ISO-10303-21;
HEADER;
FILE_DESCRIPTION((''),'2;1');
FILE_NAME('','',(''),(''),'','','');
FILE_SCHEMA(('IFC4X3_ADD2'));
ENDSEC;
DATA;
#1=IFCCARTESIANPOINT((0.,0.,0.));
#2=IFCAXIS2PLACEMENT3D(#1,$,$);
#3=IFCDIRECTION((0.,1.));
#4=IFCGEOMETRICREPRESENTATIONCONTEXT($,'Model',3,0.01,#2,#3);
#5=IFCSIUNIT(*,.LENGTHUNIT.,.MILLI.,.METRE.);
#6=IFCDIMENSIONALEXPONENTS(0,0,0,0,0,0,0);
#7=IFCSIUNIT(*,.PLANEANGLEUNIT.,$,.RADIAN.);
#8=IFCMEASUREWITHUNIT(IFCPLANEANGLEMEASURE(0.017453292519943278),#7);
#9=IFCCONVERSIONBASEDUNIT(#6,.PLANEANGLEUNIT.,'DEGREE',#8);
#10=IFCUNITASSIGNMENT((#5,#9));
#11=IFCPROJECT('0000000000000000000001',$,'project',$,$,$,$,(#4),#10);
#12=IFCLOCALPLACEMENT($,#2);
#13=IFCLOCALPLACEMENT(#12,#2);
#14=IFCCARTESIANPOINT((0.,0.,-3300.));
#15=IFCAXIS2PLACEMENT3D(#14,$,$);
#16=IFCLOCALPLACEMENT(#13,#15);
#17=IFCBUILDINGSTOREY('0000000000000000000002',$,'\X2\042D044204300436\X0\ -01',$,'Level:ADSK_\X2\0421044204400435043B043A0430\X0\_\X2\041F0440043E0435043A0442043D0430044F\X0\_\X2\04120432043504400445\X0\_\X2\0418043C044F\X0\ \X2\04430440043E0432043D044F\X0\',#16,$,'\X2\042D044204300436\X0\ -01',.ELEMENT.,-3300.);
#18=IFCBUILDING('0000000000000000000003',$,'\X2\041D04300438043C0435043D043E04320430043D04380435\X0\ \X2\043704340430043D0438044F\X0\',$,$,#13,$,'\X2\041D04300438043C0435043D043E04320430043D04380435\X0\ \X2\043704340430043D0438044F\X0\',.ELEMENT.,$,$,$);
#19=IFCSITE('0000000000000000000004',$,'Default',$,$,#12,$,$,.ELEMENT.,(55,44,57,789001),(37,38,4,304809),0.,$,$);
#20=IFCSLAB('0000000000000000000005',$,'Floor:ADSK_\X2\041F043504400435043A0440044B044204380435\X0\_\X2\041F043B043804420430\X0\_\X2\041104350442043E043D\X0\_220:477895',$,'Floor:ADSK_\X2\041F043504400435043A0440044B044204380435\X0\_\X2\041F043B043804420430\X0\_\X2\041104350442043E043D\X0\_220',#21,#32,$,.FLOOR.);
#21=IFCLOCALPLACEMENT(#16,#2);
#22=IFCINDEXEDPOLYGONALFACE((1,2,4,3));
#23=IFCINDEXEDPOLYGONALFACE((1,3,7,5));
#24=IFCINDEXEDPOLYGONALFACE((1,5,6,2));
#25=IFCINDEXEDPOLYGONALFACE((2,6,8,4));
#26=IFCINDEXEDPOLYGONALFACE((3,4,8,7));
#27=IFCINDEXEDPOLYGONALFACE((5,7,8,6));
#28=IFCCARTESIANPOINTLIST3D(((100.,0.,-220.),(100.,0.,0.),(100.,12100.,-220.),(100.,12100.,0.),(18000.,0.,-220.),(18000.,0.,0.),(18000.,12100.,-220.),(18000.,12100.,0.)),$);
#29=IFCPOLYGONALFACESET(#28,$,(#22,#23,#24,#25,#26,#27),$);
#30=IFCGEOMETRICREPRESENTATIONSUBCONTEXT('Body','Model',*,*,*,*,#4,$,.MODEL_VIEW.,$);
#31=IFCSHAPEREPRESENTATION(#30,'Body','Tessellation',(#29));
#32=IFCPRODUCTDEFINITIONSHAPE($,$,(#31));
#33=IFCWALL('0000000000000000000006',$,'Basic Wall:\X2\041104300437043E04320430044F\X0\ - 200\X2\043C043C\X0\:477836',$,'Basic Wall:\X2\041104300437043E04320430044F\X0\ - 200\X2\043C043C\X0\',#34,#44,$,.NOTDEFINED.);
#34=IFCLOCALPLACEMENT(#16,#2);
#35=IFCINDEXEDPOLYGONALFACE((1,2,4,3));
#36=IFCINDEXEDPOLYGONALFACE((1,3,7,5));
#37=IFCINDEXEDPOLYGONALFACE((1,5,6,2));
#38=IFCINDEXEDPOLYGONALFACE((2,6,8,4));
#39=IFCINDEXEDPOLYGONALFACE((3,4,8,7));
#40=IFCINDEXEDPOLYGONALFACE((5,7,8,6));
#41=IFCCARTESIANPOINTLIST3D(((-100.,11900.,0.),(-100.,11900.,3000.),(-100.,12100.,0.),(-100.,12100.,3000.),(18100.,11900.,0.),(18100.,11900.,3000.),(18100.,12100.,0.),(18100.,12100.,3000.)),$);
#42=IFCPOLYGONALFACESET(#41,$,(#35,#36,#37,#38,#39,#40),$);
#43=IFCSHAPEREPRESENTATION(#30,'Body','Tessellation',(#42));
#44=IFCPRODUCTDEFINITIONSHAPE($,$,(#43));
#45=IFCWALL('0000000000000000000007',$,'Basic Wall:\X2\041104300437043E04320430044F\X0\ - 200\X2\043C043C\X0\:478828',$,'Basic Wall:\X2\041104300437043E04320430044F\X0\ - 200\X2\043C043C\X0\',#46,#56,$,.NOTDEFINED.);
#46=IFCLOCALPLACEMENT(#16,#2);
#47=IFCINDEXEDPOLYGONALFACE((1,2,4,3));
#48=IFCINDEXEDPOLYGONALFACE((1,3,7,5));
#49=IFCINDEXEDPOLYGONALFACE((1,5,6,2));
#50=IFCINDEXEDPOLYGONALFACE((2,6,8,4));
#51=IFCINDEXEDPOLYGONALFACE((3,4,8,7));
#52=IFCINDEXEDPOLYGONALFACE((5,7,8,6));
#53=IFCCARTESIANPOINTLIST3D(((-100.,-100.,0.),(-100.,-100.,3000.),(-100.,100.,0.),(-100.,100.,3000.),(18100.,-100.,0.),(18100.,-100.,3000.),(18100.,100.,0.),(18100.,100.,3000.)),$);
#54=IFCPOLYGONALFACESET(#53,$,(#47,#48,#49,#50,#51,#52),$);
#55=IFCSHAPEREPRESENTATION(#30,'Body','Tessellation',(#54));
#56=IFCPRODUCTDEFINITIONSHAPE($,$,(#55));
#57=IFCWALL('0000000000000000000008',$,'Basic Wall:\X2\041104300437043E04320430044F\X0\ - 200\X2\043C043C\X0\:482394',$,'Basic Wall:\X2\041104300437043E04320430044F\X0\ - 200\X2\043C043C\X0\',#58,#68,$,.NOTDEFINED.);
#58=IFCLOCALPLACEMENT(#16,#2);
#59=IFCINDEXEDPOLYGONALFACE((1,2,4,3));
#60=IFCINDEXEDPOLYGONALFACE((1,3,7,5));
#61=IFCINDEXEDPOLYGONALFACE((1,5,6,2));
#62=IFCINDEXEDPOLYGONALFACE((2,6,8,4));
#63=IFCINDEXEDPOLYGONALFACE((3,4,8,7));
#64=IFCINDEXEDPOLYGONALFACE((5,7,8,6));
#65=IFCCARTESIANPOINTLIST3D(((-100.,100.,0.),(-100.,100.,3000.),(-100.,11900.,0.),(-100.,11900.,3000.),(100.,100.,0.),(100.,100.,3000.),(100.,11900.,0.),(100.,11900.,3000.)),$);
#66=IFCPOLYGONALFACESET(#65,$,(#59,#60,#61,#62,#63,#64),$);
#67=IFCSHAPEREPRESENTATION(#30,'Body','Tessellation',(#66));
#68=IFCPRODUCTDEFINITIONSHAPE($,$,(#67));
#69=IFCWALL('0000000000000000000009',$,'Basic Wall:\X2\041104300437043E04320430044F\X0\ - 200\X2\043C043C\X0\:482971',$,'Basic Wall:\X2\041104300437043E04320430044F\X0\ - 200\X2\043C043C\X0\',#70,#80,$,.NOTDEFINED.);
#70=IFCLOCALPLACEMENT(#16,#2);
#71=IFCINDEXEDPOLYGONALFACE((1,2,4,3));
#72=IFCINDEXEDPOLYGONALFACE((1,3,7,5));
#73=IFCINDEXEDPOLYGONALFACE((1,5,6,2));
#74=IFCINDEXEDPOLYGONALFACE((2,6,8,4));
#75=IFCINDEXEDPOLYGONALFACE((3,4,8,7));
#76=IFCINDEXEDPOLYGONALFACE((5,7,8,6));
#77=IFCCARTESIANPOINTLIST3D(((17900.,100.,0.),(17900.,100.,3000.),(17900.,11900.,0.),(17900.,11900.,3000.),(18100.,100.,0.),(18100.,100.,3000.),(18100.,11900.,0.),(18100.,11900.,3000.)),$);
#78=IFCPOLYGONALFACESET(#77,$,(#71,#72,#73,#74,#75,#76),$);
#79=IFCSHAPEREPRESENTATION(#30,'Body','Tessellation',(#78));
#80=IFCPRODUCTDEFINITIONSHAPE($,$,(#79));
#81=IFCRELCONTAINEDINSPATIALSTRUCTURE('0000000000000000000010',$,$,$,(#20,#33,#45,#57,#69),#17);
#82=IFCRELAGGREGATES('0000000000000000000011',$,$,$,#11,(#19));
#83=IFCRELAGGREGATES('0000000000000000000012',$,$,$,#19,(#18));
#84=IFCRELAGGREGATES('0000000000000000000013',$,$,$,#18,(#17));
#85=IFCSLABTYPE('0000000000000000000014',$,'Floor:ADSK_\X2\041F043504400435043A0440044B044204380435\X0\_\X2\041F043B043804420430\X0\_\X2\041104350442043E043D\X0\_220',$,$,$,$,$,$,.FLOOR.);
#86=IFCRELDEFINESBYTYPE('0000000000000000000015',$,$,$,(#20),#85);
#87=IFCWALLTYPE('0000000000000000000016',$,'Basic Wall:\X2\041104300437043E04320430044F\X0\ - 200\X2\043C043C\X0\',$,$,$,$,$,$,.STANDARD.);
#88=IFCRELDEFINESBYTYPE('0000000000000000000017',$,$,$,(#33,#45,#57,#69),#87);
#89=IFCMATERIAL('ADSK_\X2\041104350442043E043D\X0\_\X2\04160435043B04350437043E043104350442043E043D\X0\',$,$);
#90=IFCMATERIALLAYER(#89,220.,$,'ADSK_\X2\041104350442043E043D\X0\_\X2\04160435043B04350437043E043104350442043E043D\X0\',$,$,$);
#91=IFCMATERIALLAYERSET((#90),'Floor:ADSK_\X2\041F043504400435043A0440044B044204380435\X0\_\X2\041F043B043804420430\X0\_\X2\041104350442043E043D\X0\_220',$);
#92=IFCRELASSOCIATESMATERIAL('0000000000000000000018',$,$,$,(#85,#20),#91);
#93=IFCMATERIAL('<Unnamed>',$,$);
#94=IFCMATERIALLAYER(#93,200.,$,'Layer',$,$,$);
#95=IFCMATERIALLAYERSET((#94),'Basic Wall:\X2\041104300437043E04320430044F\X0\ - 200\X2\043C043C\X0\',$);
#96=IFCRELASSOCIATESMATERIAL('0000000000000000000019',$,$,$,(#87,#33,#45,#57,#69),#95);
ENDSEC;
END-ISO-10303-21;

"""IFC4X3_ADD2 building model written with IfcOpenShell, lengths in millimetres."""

from ifc_helpers import new_model, entity, si_unit, converted_unit, direction, frame, frame_2d, origin, origin_2d_with_axis, place, context, subcontext, project, spatial, rectangle, extrude, material, layer, layer_set, layer_usage, type_object, element, save


model = new_model("IFC4X3_ADD2")

# Units and contexts
model_context = context("Model", 3, precision=0.01, world=origin(), true_north=direction((0.0, 1.0)))
body_context = subcontext(model_context, "Body", "Model", "MODEL_VIEW")
ifc_project = project(units=[si_unit("LENGTHUNIT", "METRE", prefix="MILLI"), converted_unit("PLANEANGLEUNIT", "DEGREE", entity("IfcPlaneAngleMeasure", 0.017453292519943278), si_unit("PLANEANGLEUNIT", "RADIAN"), dimensions=[0, 0, 0, 0, 0, 0, 0])], contexts=[model_context])

# Site, building, storey
site_placement = place(None, origin())
site = spatial("IfcSite", under=ifc_project, at=site_placement, Name="Default", CompositionType="ELEMENT", RefLatitude=(55, 44, 57, 789001), RefLongitude=(37, 38, 4, 304809), RefElevation=0.0)
building_placement = place(site_placement, origin())
building = spatial("IfcBuilding", under=site, at=building_placement, Name="Наименование здания", LongName="Наименование здания", CompositionType="ELEMENT")
storey_placement = place(building_placement, frame((0.0, 0.0, -3300.0)))
storey = spatial("IfcBuildingStorey", under=building, at=storey_placement, Name="Этаж -01", ObjectType="Level:ADSK_Стрелка_Проектная_Вверх_Имя уровня", LongName="Этаж -01", CompositionType="ELEMENT", Elevation=-3300.0)

# Slab
ifc_material_1 = material(Name="ADSK_Бетон_Железобетон")
ifc_layer_1 = layer(ifc_material_1, 220.0, Name="ADSK_Бетон_Железобетон")
ifc_layer_set_1 = layer_set([ifc_layer_1], Name="Floor:ADSK_Перекрытие_Плита_Бетон_220")
ifc_layer_usage = layer_usage(ifc_layer_set_1, "AXIS3", "POSITIVE", 0.0)
slab_type = type_object("IfcSlabType", Name="Floor:ADSK_Перекрытие_Плита_Бетон_220", PredefinedType="FLOOR", material=ifc_layer_set_1)
slab_placement = place(storey_placement, origin())
element("IfcSlab", 1, at=slab_placement, inside=storey, type_object=slab_type, material=ifc_layer_usage, Name="Floor:ADSK_Перекрытие_Плита_Бетон_220:477895", ObjectType="Floor:ADSK_Перекрытие_Плита_Бетон_220", PredefinedType="FLOOR", context=body_context, shape_type="SweptSolid", body=[
    extrude(rectangle(XDim=12100.0, YDim=17900.0, at=origin_2d_with_axis()), frame((9050.0, 6050.0, 0.0), z_axis=(0.0, 0.0, -1.0), x_axis=(0.0, 1.0, 0.0)), (0.0, 0.0, 1.0), 220.0),
])

# Walls
ifc_material_2 = material(Name="<Unnamed>")
ifc_layer_2 = layer(ifc_material_2, 200.0, Name="Layer")
ifc_layer_set_2 = layer_set([ifc_layer_2], Name="Basic Wall:Базовая - 200мм")
wall_type = type_object("IfcWallType", Name="Basic Wall:Базовая - 200мм", PredefinedType="STANDARD", material=ifc_layer_set_2)
wall_1_placement = place(storey_placement, frame((18100.0, 12000.0, 0.0), z_axis=(0.0, 0.0, 1.0), x_axis=(-1.0, 0.0, 0.0)))
element("IfcWall", 2, at=wall_1_placement, inside=storey, type_object=wall_type, material=ifc_layer_set_2, Name="Basic Wall:Базовая - 200мм:477836", ObjectType="Basic Wall:Базовая - 200мм", PredefinedType="NOTDEFINED", context=body_context, shape_type="SweptSolid", body=[
    extrude(rectangle(XDim=18200.0, YDim=200.0, at=frame_2d((9100.0, 0.0), x_axis=(-1.0, 0.0))), origin(), (0.0, 0.0, 1.0), 3000.0),
])
wall_2_placement = place(storey_placement, frame((-100.0, 0.0, 0.0)))
element("IfcWall", 3, at=wall_2_placement, inside=storey, type_object=wall_type, material=ifc_layer_set_2, Name="Basic Wall:Базовая - 200мм:478828", ObjectType="Basic Wall:Базовая - 200мм", PredefinedType="NOTDEFINED", context=body_context, shape_type="SweptSolid", body=[
    extrude(rectangle(XDim=18200.0, YDim=200.0, at=frame_2d((9100.0, 0.0), x_axis=(-1.0, 0.0))), origin(), (0.0, 0.0, 1.0), 3000.0),
])
wall_3_placement = place(storey_placement, frame((0.0, 11900.0, 0.0), z_axis=(0.0, 0.0, 1.0), x_axis=(0.0, -1.0, 0.0)))
element("IfcWall", 4, at=wall_3_placement, inside=storey, type_object=wall_type, material=ifc_layer_set_2, Name="Basic Wall:Базовая - 200мм:482394", ObjectType="Basic Wall:Базовая - 200мм", PredefinedType="NOTDEFINED", context=body_context, shape_type="SweptSolid", body=[
    extrude(rectangle(XDim=11800.0, YDim=200.0, at=frame_2d((5900.0, 0.0), x_axis=(-1.0, 0.0))), origin(), (0.0, 0.0, 1.0), 3000.0),
])
wall_4_placement = place(storey_placement, frame((18000.0, 100.0, 0.0), z_axis=(0.0, 0.0, 1.0), x_axis=(0.0, 1.0, 0.0)))
element("IfcWall", 5, at=wall_4_placement, inside=storey, type_object=wall_type, material=ifc_layer_set_2, Name="Basic Wall:Базовая - 200мм:482971", ObjectType="Basic Wall:Базовая - 200мм", PredefinedType="NOTDEFINED", context=body_context, shape_type="SweptSolid", body=[
    extrude(rectangle(XDim=11800.0, YDim=200.0, at=frame_2d((5900.0, 0.0), x_axis=(-1.0, 0.0))), origin(), (0.0, 0.0, 1.0), 3000.0),
])

save(model, "model.ifc")
